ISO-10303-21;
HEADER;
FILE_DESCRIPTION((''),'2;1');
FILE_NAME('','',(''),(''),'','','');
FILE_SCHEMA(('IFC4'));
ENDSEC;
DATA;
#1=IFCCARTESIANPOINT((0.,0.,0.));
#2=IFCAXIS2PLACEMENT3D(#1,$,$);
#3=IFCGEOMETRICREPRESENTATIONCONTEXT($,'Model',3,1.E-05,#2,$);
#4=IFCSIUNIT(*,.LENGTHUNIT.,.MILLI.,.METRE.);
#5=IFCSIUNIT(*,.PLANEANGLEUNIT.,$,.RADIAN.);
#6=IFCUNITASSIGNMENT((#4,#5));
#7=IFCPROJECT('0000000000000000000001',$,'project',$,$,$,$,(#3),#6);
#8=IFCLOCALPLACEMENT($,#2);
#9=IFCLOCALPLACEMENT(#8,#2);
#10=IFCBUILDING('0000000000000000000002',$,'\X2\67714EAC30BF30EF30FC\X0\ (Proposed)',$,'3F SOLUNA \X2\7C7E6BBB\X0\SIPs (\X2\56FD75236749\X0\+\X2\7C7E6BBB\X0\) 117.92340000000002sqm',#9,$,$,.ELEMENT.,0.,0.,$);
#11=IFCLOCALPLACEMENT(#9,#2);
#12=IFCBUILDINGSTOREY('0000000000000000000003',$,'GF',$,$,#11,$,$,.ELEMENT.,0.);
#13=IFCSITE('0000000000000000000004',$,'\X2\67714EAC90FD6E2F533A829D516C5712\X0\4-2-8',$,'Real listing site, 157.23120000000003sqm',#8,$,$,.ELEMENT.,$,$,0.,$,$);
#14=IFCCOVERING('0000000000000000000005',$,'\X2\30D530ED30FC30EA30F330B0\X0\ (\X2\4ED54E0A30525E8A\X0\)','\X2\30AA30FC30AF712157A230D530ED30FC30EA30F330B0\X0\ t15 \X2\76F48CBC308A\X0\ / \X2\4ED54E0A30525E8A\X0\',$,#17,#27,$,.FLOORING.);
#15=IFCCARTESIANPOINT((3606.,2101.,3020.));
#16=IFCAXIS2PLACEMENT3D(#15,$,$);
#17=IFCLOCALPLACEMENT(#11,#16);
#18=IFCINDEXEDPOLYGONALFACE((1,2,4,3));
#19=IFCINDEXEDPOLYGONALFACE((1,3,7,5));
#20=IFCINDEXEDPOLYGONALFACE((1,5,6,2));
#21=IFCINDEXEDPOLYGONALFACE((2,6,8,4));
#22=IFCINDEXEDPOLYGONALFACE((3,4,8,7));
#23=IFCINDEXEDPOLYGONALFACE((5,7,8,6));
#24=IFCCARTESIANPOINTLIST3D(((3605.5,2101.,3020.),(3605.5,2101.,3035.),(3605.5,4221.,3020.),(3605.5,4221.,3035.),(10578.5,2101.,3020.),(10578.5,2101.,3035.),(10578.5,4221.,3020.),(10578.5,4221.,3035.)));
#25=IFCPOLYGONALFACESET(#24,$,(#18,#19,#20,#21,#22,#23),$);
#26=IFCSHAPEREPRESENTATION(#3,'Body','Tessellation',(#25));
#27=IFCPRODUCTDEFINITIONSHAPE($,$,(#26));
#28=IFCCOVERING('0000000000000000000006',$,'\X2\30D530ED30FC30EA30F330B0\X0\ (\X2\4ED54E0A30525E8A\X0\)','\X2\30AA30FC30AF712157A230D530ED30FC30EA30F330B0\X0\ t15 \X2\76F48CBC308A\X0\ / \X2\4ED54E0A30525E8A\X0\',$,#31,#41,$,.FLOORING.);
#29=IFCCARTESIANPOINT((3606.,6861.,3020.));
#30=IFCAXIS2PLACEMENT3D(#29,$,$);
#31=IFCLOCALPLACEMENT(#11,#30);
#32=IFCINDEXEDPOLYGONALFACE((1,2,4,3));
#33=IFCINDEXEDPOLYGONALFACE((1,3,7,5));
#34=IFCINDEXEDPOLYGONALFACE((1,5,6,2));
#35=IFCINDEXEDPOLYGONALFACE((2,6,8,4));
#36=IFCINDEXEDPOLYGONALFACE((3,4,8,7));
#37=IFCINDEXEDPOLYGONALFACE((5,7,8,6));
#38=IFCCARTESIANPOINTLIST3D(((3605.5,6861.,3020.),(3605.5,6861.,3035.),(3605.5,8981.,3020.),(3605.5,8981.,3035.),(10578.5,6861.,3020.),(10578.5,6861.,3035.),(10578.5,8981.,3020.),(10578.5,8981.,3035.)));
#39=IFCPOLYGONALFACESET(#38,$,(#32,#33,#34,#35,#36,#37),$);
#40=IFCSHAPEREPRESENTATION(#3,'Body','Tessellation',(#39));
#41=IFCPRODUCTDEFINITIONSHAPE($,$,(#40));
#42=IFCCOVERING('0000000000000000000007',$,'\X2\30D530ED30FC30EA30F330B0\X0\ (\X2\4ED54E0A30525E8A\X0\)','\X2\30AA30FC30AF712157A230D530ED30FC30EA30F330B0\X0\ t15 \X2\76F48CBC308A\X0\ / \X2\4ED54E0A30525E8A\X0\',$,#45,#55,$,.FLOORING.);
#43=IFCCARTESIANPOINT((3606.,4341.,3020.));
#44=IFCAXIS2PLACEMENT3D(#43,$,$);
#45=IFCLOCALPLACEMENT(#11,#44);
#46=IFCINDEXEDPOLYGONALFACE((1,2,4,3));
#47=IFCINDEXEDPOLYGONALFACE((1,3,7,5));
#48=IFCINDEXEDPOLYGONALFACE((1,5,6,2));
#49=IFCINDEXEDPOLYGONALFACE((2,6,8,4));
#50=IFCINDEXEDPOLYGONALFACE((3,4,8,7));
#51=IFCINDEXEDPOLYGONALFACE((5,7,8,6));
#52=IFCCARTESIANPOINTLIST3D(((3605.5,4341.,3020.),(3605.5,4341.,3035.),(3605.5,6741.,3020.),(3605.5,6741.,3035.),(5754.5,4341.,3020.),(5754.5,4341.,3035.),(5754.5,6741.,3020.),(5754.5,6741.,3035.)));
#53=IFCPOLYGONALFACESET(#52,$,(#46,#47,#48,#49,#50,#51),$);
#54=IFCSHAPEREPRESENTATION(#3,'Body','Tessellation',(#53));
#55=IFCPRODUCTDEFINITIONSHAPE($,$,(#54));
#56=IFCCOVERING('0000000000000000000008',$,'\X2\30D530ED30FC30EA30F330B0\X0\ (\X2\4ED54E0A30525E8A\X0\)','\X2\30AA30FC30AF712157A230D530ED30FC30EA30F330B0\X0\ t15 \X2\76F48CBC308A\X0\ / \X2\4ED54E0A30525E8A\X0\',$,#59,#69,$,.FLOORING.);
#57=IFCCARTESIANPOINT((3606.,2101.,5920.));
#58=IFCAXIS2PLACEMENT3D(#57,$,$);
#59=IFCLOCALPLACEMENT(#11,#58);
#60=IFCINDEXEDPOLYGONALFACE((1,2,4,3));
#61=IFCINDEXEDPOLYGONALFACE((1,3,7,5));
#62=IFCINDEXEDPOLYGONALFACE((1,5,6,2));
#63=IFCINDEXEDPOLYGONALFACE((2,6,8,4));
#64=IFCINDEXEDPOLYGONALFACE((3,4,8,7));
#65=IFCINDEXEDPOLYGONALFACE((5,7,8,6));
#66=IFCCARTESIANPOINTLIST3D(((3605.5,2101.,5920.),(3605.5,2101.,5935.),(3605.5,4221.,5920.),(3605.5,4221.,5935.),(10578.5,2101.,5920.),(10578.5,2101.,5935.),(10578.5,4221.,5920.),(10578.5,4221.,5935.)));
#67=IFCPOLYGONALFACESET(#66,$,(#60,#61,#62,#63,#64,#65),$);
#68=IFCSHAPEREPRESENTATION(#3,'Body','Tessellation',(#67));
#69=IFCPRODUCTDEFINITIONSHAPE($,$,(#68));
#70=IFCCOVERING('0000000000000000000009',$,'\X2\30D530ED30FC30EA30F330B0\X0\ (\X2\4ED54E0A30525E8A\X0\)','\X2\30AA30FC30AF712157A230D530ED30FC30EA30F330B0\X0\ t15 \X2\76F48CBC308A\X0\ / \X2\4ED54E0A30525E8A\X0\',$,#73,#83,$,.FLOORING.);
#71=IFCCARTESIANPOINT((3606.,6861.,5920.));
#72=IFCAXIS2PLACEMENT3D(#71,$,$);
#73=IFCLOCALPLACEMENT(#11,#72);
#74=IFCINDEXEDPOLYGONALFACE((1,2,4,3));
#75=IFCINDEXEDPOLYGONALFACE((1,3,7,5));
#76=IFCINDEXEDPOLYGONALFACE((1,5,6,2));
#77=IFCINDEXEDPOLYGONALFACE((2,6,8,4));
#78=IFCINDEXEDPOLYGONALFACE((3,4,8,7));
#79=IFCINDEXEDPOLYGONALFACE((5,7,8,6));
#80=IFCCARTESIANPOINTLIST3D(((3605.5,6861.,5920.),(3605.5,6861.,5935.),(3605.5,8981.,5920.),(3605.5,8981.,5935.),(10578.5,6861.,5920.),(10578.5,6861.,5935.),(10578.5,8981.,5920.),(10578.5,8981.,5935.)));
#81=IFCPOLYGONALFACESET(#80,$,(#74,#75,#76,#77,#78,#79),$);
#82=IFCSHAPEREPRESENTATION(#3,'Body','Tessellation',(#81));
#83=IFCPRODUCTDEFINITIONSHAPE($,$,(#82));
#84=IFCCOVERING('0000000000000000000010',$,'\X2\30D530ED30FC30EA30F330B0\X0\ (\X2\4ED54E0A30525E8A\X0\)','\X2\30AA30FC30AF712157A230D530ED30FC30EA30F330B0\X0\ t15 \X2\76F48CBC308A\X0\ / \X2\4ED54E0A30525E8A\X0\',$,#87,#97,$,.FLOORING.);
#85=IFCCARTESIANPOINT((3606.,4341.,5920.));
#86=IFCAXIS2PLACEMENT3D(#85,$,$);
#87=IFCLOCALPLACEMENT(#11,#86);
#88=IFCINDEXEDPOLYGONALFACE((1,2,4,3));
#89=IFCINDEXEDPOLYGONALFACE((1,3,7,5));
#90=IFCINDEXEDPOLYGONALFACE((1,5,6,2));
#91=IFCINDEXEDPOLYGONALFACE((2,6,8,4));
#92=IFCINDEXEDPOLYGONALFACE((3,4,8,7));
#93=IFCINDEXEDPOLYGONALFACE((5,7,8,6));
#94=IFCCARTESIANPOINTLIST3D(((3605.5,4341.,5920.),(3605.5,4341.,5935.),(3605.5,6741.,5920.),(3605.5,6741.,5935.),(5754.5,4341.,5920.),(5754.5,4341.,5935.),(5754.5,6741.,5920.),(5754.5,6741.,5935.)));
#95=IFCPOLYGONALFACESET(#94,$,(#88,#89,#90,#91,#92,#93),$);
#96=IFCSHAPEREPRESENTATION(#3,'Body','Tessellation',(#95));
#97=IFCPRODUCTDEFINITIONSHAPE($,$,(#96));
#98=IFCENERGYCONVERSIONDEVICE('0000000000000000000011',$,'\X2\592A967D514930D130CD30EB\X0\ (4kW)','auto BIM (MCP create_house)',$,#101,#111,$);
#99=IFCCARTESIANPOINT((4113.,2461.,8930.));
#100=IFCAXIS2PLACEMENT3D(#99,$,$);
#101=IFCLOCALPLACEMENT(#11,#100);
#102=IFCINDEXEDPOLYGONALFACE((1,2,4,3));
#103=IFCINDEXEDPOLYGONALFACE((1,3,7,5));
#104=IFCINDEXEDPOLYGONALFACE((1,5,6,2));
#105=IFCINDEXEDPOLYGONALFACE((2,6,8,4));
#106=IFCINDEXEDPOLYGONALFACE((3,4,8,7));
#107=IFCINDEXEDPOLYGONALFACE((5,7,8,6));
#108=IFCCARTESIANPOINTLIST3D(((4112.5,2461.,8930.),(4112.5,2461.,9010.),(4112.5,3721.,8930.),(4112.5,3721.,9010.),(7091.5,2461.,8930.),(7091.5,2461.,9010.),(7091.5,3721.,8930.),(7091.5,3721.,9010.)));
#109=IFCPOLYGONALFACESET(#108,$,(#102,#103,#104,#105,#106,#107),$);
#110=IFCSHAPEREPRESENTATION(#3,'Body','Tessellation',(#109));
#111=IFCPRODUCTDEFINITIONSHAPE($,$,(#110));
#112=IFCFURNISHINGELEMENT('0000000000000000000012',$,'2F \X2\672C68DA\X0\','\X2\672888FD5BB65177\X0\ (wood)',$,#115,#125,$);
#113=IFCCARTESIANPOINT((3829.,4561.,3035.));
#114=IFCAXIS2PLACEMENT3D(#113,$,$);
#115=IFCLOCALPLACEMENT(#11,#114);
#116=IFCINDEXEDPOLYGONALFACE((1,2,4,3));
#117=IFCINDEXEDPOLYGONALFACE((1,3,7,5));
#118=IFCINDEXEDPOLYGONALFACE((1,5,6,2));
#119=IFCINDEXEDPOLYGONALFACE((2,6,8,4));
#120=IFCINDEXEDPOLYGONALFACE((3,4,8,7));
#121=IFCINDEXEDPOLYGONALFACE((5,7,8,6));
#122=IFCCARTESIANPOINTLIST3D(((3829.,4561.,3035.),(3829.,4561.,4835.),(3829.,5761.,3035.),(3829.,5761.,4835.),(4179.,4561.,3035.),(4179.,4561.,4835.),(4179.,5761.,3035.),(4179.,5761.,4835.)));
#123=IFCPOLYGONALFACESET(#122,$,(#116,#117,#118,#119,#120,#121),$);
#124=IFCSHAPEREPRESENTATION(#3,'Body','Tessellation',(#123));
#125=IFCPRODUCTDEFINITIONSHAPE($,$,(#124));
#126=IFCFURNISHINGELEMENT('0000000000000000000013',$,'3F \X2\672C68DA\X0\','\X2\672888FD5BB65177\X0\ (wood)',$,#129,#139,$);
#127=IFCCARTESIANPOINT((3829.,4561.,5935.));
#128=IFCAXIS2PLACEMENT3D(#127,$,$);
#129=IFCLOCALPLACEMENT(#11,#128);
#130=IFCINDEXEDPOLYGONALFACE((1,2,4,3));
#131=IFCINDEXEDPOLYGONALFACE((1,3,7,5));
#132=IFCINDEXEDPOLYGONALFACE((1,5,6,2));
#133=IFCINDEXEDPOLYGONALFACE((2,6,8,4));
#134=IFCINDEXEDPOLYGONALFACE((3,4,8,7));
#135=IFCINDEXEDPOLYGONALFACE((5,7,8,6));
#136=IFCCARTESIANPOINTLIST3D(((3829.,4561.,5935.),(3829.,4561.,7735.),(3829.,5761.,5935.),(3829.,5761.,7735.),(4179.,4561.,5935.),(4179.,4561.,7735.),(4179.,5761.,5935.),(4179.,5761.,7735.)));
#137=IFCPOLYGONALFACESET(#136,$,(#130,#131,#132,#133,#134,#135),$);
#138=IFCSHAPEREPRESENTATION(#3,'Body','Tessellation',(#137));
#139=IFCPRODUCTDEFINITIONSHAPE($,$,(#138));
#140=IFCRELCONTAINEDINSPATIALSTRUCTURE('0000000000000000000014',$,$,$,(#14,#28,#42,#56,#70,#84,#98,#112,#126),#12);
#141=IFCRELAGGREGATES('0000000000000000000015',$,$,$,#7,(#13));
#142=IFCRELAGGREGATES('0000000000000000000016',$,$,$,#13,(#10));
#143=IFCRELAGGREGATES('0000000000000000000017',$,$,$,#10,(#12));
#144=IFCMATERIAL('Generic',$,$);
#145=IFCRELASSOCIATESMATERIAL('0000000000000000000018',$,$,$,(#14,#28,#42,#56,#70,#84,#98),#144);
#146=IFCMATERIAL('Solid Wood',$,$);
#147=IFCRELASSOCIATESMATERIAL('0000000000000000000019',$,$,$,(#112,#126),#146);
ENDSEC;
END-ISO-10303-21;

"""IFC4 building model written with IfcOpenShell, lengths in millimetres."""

from ifc_helpers import new_model, si_unit, frame, frame_2d, origin, place, context, project, spatial, rectangle, extrude, material, element, save


model = new_model("IFC4")

# Units and contexts
model_context = context("Model", 3, precision=1e-05, world=origin())
ifc_project = project(units=[si_unit("LENGTHUNIT", "METRE", prefix="MILLI"), si_unit("PLANEANGLEUNIT", "RADIAN")], contexts=[model_context])

# Site, building, storey
site_placement = place(None, origin())
site = spatial("IfcSite", under=ifc_project, at=site_placement, Name="東京都港区芝公園4-2-8", ObjectType="Real listing site, 157.23120000000003sqm", CompositionType="ELEMENT", RefElevation=0.0)
building_placement = place(site_placement, origin())
building = spatial("IfcBuilding", under=site, at=building_placement, Name="東京タワー (Proposed)", ObjectType="3F SOLUNA 籾殻SIPs (国産杉+籾殻) 117.92340000000002sqm", CompositionType="ELEMENT", ElevationOfRefHeight=0.0, ElevationOfTerrain=0.0)
storey_placement = place(building_placement, origin())
storey = spatial("IfcBuildingStorey", under=building, at=storey_placement, Name="GF", CompositionType="ELEMENT", Elevation=0.0)

# Shared definitions
ifc_material_1 = material(Name="Solid Wood")

# Coverings
ifc_material_2 = material(Name="Generic")
covering_1_placement = place(storey_placement, frame((3606.0, 2101.0, 3020.0)))
element("IfcCovering", 1, at=covering_1_placement, inside=storey, material=ifc_material_2, Name="フローリング (仕上げ床)", Description="オーク無垢フローリング t15 直貼り / 仕上げ床", PredefinedType="FLOORING", context=model_context, shape_type="SweptSolid", body=[
    extrude(rectangle(XDim=6973.0, YDim=2120.0, at=frame_2d((3486.0, 1060.0))), frame((3606.0, 2101.0, 3020.0)), (0.0, 0.0, 1.0), 15.0),
])
covering_2_placement = place(storey_placement, frame((3606.0, 6861.0, 3020.0)))
element("IfcCovering", 2, at=covering_2_placement, inside=storey, material=ifc_material_2, Name="フローリング (仕上げ床)", Description="オーク無垢フローリング t15 直貼り / 仕上げ床", PredefinedType="FLOORING", context=model_context, shape_type="SweptSolid", body=[
    extrude(rectangle(XDim=6973.0, YDim=2120.0, at=frame_2d((3486.0, 1060.0))), frame((3606.0, 6861.0, 3020.0)), (0.0, 0.0, 1.0), 15.0),
])
covering_3_placement = place(storey_placement, frame((3606.0, 4341.0, 3020.0)))
element("IfcCovering", 3, at=covering_3_placement, inside=storey, material=ifc_material_2, Name="フローリング (仕上げ床)", Description="オーク無垢フローリング t15 直貼り / 仕上げ床", PredefinedType="FLOORING", context=model_context, shape_type="SweptSolid", body=[
    extrude(rectangle(XDim=2149.0, YDim=2400.0, at=frame_2d((1074.0, 1200.0))), frame((3606.0, 4341.0, 3020.0)), (0.0, 0.0, 1.0), 15.0),
])
covering_4_placement = place(storey_placement, frame((3606.0, 2101.0, 5920.0)))
element("IfcCovering", 4, at=covering_4_placement, inside=storey, material=ifc_material_2, Name="フローリング (仕上げ床)", Description="オーク無垢フローリング t15 直貼り / 仕上げ床", PredefinedType="FLOORING", context=model_context, shape_type="SweptSolid", body=[
    extrude(rectangle(XDim=6973.0, YDim=2120.0, at=frame_2d((3486.0, 1060.0))), frame((3606.0, 2101.0, 5920.0)), (0.0, 0.0, 1.0), 15.0),
])
covering_5_placement = place(storey_placement, frame((3606.0, 6861.0, 5920.0)))
element("IfcCovering", 5, at=covering_5_placement, inside=storey, material=ifc_material_2, Name="フローリング (仕上げ床)", Description="オーク無垢フローリング t15 直貼り / 仕上げ床", PredefinedType="FLOORING", context=model_context, shape_type="SweptSolid", body=[
    extrude(rectangle(XDim=6973.0, YDim=2120.0, at=frame_2d((3486.0, 1060.0))), frame((3606.0, 6861.0, 5920.0)), (0.0, 0.0, 1.0), 15.0),
])
covering_6_placement = place(storey_placement, frame((3606.0, 4341.0, 5920.0)))
element("IfcCovering", 6, at=covering_6_placement, inside=storey, material=ifc_material_2, Name="フローリング (仕上げ床)", Description="オーク無垢フローリング t15 直貼り / 仕上げ床", PredefinedType="FLOORING", context=model_context, shape_type="SweptSolid", body=[
    extrude(rectangle(XDim=2149.0, YDim=2400.0, at=frame_2d((1074.0, 1200.0))), frame((3606.0, 4341.0, 5920.0)), (0.0, 0.0, 1.0), 15.0),
])

# Energy conversion device
energy_conversion_device_placement = place(storey_placement, frame((4113.0, 2461.0, 8930.0)))
element("IfcEnergyConversionDevice", 7, at=energy_conversion_device_placement, inside=storey, material=ifc_material_2, Name="太陽光パネル (4kW)", Description="auto BIM (MCP create_house)", context=model_context, shape_type="SweptSolid", body=[
    extrude(rectangle(XDim=2979.0, YDim=1260.0, at=frame_2d((1489.0, 630.0))), frame((4113.0, 2461.0, 8930.0)), (0.0, 0.0, 1.0), 80.0),
])

# Furnishing elements
furnishing_1_placement = place(storey_placement, frame((3829.0, 4561.0, 3035.0)))
element("IfcFurnishingElement", 8, at=furnishing_1_placement, inside=storey, material=ifc_material_1, Name="2F 本棚", Description="木製家具 (wood)", context=model_context, shape_type="SweptSolid", body=[
    extrude(rectangle(XDim=350.0, YDim=1200.0, at=frame_2d((175.0, 600.0))), frame((3829.0, 4561.0, 3035.0)), (0.0, 0.0, 1.0), 1800.0),
])
furnishing_2_placement = place(storey_placement, frame((3829.0, 4561.0, 5935.0)))
element("IfcFurnishingElement", 9, at=furnishing_2_placement, inside=storey, material=ifc_material_1, Name="3F 本棚", Description="木製家具 (wood)", context=model_context, shape_type="SweptSolid", body=[
    extrude(rectangle(XDim=350.0, YDim=1200.0, at=frame_2d((175.0, 600.0))), frame((3829.0, 4561.0, 5935.0)), (0.0, 0.0, 1.0), 1800.0),
])

save(model, "model.ifc")
